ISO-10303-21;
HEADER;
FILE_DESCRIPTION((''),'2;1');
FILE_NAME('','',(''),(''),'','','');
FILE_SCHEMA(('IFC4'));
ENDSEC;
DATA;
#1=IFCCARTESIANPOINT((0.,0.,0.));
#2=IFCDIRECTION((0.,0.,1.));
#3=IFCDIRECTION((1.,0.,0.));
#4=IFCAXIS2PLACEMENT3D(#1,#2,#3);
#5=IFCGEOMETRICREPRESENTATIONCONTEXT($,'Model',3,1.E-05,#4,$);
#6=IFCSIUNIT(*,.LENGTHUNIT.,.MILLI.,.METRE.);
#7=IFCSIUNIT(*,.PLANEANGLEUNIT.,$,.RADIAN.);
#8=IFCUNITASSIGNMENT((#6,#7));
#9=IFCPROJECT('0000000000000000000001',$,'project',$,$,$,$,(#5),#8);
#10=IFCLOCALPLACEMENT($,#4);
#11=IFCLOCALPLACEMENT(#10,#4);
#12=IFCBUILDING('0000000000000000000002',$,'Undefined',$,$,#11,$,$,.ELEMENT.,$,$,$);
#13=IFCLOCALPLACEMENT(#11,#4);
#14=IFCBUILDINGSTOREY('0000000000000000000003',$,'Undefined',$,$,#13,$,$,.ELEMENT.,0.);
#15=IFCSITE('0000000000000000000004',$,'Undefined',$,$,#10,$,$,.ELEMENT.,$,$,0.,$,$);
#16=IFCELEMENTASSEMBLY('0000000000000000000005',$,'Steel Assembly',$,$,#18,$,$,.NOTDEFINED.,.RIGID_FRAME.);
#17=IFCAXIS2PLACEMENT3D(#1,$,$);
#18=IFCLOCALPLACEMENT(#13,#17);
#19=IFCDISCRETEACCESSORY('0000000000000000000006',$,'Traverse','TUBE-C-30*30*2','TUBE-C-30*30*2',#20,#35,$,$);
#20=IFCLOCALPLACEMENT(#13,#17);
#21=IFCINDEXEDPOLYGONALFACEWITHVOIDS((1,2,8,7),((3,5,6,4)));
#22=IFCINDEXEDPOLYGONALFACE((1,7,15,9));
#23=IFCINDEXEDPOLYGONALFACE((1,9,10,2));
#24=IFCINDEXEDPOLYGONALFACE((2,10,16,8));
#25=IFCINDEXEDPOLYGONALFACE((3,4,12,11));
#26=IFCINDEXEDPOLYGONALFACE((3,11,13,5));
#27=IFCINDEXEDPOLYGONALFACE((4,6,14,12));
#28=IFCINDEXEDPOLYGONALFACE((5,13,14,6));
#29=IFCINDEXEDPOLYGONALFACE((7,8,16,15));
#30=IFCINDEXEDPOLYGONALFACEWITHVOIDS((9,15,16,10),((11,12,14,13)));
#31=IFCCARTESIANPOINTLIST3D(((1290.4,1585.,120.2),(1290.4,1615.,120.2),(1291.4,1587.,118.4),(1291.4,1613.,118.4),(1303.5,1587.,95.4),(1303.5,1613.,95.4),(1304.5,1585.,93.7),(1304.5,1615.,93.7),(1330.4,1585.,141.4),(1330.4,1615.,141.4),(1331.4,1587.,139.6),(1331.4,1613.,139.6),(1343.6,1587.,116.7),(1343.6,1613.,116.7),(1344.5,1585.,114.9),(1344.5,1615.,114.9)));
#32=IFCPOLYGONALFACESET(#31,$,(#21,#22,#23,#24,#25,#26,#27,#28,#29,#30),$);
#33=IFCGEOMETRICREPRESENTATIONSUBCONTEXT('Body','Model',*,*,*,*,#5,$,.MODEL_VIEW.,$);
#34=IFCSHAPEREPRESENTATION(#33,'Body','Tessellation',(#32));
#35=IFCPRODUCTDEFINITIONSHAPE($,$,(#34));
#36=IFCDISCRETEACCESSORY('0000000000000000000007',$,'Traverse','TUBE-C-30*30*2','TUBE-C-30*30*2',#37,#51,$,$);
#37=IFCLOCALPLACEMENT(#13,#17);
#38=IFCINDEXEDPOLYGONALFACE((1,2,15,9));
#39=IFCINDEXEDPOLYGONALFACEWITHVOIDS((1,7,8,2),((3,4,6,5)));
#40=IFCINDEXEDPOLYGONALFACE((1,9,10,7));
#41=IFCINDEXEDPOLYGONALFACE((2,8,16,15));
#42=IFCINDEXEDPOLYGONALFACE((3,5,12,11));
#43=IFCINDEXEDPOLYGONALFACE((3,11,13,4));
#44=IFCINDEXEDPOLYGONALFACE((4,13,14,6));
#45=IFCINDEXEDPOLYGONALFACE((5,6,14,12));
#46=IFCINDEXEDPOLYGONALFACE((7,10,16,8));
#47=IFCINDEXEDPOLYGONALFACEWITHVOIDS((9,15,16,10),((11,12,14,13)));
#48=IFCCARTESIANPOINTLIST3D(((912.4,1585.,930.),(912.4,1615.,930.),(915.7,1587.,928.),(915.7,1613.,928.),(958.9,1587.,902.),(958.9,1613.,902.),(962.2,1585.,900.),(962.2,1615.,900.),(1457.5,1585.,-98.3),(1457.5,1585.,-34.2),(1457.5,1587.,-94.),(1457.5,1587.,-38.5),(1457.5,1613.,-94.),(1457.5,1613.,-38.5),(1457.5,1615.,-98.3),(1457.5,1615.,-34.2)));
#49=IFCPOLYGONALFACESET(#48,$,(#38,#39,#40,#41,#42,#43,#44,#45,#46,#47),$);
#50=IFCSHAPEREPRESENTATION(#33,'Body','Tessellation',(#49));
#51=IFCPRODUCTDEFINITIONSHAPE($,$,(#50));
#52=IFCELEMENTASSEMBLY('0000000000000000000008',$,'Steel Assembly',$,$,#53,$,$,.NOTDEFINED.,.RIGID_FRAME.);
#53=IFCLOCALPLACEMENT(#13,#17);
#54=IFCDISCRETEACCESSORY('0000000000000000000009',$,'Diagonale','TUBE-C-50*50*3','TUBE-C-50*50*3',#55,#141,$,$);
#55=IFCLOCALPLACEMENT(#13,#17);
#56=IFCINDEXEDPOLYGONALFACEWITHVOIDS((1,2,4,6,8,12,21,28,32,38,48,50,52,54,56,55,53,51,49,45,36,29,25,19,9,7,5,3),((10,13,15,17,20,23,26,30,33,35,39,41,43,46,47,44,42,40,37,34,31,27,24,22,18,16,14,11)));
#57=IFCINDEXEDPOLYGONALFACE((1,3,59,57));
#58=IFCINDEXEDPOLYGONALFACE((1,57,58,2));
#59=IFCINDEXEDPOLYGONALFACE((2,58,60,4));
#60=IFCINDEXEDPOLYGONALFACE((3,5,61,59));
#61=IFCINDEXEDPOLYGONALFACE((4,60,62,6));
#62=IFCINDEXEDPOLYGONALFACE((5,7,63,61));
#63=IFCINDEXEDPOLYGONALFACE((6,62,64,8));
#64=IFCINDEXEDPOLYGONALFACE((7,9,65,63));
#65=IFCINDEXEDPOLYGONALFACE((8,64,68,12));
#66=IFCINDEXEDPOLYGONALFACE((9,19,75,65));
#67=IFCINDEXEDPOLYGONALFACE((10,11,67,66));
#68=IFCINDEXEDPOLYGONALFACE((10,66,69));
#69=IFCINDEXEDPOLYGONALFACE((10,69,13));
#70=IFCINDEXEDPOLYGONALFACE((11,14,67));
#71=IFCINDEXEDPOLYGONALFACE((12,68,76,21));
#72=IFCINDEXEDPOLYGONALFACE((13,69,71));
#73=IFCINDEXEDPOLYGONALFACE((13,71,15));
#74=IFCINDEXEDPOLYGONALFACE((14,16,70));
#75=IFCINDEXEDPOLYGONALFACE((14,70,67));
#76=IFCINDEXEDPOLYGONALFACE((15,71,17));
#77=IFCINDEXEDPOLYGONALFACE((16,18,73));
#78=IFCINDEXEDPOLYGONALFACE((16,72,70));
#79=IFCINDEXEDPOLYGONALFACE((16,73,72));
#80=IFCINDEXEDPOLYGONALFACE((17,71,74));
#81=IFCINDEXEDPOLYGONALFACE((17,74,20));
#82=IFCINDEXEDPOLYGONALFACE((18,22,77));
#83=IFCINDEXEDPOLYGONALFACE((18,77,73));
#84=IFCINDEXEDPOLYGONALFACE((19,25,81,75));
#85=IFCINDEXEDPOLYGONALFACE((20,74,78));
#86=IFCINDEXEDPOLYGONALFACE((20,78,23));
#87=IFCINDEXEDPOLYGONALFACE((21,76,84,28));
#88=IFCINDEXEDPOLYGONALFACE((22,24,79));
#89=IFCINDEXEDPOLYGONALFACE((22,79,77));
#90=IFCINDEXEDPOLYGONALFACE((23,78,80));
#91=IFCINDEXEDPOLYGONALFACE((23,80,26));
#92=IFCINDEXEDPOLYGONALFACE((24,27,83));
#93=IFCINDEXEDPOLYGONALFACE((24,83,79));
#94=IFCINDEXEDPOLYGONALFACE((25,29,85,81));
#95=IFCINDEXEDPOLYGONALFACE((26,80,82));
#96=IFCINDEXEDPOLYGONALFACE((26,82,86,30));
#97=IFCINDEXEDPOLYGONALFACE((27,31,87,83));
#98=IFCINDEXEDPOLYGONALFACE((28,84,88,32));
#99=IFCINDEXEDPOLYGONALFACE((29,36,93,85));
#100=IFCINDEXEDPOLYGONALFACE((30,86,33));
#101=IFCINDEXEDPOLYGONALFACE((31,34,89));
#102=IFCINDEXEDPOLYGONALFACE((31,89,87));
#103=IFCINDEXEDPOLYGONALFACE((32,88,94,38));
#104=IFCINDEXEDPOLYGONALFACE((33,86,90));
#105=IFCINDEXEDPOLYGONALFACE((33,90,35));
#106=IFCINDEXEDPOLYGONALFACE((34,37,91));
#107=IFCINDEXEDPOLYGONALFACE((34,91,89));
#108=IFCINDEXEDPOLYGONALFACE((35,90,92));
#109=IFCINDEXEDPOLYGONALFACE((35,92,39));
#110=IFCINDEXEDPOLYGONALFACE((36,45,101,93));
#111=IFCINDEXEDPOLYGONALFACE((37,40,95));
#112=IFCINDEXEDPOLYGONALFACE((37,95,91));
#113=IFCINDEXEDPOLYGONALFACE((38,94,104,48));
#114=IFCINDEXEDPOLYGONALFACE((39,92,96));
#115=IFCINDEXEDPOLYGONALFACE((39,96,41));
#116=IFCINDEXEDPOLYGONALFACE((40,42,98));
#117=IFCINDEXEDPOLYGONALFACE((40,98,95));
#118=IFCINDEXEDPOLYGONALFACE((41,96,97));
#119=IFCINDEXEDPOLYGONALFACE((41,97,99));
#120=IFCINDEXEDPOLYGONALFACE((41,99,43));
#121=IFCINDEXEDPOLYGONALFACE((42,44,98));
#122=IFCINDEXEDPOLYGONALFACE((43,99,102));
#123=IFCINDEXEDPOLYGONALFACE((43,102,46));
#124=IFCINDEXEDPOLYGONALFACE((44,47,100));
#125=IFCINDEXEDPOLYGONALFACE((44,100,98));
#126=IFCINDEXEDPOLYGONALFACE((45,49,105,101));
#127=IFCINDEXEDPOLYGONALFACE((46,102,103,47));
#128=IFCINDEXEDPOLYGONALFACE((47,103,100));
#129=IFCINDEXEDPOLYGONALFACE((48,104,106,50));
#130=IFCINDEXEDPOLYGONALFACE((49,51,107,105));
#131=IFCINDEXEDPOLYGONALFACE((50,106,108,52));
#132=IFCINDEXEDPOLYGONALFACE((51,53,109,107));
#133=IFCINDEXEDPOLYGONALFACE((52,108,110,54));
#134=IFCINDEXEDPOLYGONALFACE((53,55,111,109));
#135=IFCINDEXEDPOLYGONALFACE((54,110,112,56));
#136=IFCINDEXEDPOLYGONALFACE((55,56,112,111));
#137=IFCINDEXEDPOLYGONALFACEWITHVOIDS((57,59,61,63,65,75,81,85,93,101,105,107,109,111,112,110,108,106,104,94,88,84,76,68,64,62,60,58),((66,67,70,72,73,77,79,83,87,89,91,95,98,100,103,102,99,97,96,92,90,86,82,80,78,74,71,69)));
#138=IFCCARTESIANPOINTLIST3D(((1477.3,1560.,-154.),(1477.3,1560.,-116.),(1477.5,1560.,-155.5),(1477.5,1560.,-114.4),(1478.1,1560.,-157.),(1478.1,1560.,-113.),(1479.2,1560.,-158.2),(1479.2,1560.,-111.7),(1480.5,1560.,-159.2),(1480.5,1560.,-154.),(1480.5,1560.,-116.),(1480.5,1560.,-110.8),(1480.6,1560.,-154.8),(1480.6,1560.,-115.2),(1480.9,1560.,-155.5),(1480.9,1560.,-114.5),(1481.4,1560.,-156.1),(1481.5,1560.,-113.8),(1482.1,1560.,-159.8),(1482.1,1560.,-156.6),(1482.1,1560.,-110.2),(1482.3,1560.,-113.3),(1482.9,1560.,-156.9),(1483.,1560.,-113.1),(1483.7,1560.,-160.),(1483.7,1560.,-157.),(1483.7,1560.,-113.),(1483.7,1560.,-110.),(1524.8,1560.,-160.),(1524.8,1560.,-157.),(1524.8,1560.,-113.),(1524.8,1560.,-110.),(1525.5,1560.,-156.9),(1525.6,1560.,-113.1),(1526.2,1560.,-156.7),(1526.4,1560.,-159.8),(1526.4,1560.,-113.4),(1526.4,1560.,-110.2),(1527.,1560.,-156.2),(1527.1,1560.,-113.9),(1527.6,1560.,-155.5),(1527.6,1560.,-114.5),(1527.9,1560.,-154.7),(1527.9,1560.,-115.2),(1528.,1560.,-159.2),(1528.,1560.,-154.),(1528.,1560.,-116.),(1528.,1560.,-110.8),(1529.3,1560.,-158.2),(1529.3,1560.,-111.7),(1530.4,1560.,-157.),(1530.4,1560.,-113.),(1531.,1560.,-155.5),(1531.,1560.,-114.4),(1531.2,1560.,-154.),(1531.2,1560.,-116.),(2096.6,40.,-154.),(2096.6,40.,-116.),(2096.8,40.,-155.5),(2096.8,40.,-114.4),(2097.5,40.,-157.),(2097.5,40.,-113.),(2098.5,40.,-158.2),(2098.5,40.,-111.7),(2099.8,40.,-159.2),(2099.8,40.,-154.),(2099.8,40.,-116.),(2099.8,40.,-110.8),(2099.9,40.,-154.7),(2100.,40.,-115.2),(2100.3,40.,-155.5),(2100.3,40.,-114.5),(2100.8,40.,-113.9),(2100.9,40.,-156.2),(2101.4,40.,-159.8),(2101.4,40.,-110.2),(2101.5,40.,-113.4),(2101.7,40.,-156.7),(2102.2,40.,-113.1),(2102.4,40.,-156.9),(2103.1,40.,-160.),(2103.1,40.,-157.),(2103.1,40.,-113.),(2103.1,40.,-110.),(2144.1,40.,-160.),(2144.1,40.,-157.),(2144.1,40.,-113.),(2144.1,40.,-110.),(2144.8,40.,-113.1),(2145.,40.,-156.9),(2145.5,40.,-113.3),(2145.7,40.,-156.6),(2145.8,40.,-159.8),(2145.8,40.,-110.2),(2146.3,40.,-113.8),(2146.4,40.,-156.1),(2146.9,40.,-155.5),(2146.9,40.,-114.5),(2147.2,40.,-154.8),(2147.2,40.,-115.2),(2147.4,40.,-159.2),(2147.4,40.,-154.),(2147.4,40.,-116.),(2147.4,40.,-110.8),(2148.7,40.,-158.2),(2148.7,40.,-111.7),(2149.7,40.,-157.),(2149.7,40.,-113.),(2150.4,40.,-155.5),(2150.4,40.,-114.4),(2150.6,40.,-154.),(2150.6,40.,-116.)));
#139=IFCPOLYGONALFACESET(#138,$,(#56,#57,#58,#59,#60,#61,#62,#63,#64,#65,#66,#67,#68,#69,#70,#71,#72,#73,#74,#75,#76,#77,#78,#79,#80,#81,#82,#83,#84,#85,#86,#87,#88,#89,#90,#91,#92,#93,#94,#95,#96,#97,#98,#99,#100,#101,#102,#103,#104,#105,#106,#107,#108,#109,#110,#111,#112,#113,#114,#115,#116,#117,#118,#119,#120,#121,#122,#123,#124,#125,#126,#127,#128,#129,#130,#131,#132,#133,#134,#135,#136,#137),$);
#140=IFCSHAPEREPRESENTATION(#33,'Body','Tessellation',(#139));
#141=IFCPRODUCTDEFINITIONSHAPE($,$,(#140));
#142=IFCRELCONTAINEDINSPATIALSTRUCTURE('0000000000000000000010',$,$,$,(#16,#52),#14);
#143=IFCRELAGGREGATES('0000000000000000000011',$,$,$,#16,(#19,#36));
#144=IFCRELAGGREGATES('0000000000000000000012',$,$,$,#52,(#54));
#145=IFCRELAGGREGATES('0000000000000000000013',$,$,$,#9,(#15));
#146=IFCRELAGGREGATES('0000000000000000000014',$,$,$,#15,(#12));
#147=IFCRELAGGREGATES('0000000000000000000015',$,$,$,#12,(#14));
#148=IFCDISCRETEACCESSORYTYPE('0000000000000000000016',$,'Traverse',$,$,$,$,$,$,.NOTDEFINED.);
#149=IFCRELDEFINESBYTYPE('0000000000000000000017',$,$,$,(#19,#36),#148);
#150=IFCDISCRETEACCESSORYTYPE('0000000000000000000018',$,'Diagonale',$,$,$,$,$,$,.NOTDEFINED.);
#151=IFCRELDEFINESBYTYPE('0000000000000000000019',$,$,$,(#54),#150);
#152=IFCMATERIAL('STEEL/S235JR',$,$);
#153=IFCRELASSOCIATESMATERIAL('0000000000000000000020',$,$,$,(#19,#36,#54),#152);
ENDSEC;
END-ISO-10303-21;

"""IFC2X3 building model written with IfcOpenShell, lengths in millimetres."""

from ifc_helpers import new_model, si_unit, frame, origin_with_axes, origin_2d_with_axis, place, context, subcontext, project, spatial, hollow_rectangle, extrude, clip, halfspace, material, type_object, element, aggregate, save


model = new_model("IFC2X3")

# Units and contexts
model_context = context("Model", 3, precision=1e-05, world=origin_with_axes())
body_context = subcontext(model_context, "Body", "Model", "MODEL_VIEW")
ifc_project = project(units=[si_unit("LENGTHUNIT", "METRE", prefix="MILLI"), si_unit("PLANEANGLEUNIT", "RADIAN")], contexts=[model_context])

# Site, building, storey
site_placement = place(None, origin_with_axes())
site = spatial("IfcSite", under=ifc_project, at=site_placement, Name="Undefined", CompositionType="ELEMENT", RefElevation=0.0)
building_placement = place(site_placement, origin_with_axes())
building = spatial("IfcBuilding", under=site, at=building_placement, Name="Undefined", CompositionType="ELEMENT")
storey_placement = place(building_placement, origin_with_axes())
storey = spatial("IfcBuildingStorey", under=building, at=storey_placement, Name="Undefined", CompositionType="ELEMENT", Elevation=0.0)

# Element assembly
ifc_material = material(Name="STEEL/S235JR")
assembly_1_placement = place(storey_placement, origin_with_axes())
assembly_1 = element("IfcElementAssembly", 1, at=assembly_1_placement, inside=storey, Name="Steel Assembly", AssemblyPlace="NOTDEFINED", PredefinedType="RIGID_FRAME")

# Discrete accessories
discrete_accessory_type_1 = type_object("IfcDiscreteAccessoryType", Name="Traverse")
discrete_accessory_1_placement = place(assembly_1_placement, frame((1337.5, 1600.0, 128.2), z_axis=(0.0, 1.0, 0.0), x_axis=(-0.883506, 0.0, -0.46842)))
discrete_accessory_1 = element("IfcDiscreteAccessory", 2, at=discrete_accessory_1_placement, type_object=discrete_accessory_type_1, material=ifc_material, Name="Traverse", Description="TUBE-C-30*30*2", ObjectType="TUBE-C-30*30*2", context=body_context, shape_type="SweptSolid", body=[
    extrude(hollow_rectangle(XDim=30.0, YDim=30.0, WallThickness=2.0, at=origin_2d_with_axis()), frame((45.3, 0.0, 0.0), z_axis=(-1.0, 0.0, 0.0), x_axis=(0.0, -1.0, 0.0)), (0.0, 0.0, 1.0), 45.3),
])
discrete_accessory_2_placement = place(assembly_1_placement, frame((1482.7, 1600.0, -113.8), z_axis=(0.0, 1.0, 0.0), x_axis=(-0.46842, 0.0, 0.883506)))
discrete_accessory_2 = element("IfcDiscreteAccessory", 3, at=discrete_accessory_2_placement, type_object=discrete_accessory_type_1, material=ifc_material, Name="Traverse", Description="TUBE-C-30*30*2", ObjectType="TUBE-C-30*30*2", context=body_context, shape_type="Clipping", body=[
    clip(clip(extrude(hollow_rectangle(XDim=30.0, YDim=30.0, WallThickness=2.0, at=origin_2d_with_axis()), frame((1218.2, 0.0, 0.0), z_axis=(-1.0, 0.0, 0.0), x_axis=(0.0, -1.0, 0.0)), (0.0, 0.0, 1.0), 1218.2), halfspace(frame((1139.5, 15.0, 0.0), z_axis=(-0.515548, -0.856861, -0.000003), x_axis=(0.000003, -0.000005, 1.0)), True)), halfspace(frame((82.1, 15.0, 0.0), z_axis=(-0.46842, 0.883506, 0.000005), x_axis=(0.000003, -0.000005, 1.0)), False)),
])
aggregate(assembly_1, [discrete_accessory_1, discrete_accessory_2])

# Element assembly, discrete accessory
assembly_2_placement = place(storey_placement, origin_with_axes())
assembly_2 = element("IfcElementAssembly", 4, at=assembly_2_placement, inside=storey, Name="Steel Assembly", AssemblyPlace="NOTDEFINED", PredefinedType="RIGID_FRAME")
discrete_accessory_type_2 = type_object("IfcDiscreteAccessoryType", Name="Diagonale")
discrete_accessory_3_placement = place(assembly_2_placement, frame((1496.5, 1579.1, -135.0), z_axis=(0.926073, 0.377344, 0.0), x_axis=(0.377344, -0.926073, 0.0)))
discrete_accessory_3 = element("IfcDiscreteAccessory", 5, at=discrete_accessory_3_placement, type_object=discrete_accessory_type_2, material=ifc_material, Name="Diagonale", Description="TUBE-C-50*50*3", ObjectType="TUBE-C-50*50*3", context=body_context, shape_type="Clipping", body=[
    clip(clip(extrude(hollow_rectangle(XDim=50.0, YDim=50.0, WallThickness=3.0, InnerFilletRadius=3.0, OuterFilletRadius=6.0, at=origin_2d_with_axis()), frame((1682.5, 0.0, 0.0), z_axis=(-1.0, 0.0, 0.0), x_axis=(0.0, -1.0, 0.0)), (0.0, 0.0, 1.0), 1682.5), halfspace(frame((10.4, 25.0, -25.0), z_axis=(-0.926073, 0.0, 0.377344), x_axis=(0.377344, 0.0, 0.926073)), False)), halfspace(frame((1651.7, -25.0, -25.0), z_axis=(0.926073, 0.0, -0.377344), x_axis=(0.377344, 0.0, 0.926073)), False)),
])
aggregate(assembly_2, [discrete_accessory_3])

save(model, "model.ifc")
